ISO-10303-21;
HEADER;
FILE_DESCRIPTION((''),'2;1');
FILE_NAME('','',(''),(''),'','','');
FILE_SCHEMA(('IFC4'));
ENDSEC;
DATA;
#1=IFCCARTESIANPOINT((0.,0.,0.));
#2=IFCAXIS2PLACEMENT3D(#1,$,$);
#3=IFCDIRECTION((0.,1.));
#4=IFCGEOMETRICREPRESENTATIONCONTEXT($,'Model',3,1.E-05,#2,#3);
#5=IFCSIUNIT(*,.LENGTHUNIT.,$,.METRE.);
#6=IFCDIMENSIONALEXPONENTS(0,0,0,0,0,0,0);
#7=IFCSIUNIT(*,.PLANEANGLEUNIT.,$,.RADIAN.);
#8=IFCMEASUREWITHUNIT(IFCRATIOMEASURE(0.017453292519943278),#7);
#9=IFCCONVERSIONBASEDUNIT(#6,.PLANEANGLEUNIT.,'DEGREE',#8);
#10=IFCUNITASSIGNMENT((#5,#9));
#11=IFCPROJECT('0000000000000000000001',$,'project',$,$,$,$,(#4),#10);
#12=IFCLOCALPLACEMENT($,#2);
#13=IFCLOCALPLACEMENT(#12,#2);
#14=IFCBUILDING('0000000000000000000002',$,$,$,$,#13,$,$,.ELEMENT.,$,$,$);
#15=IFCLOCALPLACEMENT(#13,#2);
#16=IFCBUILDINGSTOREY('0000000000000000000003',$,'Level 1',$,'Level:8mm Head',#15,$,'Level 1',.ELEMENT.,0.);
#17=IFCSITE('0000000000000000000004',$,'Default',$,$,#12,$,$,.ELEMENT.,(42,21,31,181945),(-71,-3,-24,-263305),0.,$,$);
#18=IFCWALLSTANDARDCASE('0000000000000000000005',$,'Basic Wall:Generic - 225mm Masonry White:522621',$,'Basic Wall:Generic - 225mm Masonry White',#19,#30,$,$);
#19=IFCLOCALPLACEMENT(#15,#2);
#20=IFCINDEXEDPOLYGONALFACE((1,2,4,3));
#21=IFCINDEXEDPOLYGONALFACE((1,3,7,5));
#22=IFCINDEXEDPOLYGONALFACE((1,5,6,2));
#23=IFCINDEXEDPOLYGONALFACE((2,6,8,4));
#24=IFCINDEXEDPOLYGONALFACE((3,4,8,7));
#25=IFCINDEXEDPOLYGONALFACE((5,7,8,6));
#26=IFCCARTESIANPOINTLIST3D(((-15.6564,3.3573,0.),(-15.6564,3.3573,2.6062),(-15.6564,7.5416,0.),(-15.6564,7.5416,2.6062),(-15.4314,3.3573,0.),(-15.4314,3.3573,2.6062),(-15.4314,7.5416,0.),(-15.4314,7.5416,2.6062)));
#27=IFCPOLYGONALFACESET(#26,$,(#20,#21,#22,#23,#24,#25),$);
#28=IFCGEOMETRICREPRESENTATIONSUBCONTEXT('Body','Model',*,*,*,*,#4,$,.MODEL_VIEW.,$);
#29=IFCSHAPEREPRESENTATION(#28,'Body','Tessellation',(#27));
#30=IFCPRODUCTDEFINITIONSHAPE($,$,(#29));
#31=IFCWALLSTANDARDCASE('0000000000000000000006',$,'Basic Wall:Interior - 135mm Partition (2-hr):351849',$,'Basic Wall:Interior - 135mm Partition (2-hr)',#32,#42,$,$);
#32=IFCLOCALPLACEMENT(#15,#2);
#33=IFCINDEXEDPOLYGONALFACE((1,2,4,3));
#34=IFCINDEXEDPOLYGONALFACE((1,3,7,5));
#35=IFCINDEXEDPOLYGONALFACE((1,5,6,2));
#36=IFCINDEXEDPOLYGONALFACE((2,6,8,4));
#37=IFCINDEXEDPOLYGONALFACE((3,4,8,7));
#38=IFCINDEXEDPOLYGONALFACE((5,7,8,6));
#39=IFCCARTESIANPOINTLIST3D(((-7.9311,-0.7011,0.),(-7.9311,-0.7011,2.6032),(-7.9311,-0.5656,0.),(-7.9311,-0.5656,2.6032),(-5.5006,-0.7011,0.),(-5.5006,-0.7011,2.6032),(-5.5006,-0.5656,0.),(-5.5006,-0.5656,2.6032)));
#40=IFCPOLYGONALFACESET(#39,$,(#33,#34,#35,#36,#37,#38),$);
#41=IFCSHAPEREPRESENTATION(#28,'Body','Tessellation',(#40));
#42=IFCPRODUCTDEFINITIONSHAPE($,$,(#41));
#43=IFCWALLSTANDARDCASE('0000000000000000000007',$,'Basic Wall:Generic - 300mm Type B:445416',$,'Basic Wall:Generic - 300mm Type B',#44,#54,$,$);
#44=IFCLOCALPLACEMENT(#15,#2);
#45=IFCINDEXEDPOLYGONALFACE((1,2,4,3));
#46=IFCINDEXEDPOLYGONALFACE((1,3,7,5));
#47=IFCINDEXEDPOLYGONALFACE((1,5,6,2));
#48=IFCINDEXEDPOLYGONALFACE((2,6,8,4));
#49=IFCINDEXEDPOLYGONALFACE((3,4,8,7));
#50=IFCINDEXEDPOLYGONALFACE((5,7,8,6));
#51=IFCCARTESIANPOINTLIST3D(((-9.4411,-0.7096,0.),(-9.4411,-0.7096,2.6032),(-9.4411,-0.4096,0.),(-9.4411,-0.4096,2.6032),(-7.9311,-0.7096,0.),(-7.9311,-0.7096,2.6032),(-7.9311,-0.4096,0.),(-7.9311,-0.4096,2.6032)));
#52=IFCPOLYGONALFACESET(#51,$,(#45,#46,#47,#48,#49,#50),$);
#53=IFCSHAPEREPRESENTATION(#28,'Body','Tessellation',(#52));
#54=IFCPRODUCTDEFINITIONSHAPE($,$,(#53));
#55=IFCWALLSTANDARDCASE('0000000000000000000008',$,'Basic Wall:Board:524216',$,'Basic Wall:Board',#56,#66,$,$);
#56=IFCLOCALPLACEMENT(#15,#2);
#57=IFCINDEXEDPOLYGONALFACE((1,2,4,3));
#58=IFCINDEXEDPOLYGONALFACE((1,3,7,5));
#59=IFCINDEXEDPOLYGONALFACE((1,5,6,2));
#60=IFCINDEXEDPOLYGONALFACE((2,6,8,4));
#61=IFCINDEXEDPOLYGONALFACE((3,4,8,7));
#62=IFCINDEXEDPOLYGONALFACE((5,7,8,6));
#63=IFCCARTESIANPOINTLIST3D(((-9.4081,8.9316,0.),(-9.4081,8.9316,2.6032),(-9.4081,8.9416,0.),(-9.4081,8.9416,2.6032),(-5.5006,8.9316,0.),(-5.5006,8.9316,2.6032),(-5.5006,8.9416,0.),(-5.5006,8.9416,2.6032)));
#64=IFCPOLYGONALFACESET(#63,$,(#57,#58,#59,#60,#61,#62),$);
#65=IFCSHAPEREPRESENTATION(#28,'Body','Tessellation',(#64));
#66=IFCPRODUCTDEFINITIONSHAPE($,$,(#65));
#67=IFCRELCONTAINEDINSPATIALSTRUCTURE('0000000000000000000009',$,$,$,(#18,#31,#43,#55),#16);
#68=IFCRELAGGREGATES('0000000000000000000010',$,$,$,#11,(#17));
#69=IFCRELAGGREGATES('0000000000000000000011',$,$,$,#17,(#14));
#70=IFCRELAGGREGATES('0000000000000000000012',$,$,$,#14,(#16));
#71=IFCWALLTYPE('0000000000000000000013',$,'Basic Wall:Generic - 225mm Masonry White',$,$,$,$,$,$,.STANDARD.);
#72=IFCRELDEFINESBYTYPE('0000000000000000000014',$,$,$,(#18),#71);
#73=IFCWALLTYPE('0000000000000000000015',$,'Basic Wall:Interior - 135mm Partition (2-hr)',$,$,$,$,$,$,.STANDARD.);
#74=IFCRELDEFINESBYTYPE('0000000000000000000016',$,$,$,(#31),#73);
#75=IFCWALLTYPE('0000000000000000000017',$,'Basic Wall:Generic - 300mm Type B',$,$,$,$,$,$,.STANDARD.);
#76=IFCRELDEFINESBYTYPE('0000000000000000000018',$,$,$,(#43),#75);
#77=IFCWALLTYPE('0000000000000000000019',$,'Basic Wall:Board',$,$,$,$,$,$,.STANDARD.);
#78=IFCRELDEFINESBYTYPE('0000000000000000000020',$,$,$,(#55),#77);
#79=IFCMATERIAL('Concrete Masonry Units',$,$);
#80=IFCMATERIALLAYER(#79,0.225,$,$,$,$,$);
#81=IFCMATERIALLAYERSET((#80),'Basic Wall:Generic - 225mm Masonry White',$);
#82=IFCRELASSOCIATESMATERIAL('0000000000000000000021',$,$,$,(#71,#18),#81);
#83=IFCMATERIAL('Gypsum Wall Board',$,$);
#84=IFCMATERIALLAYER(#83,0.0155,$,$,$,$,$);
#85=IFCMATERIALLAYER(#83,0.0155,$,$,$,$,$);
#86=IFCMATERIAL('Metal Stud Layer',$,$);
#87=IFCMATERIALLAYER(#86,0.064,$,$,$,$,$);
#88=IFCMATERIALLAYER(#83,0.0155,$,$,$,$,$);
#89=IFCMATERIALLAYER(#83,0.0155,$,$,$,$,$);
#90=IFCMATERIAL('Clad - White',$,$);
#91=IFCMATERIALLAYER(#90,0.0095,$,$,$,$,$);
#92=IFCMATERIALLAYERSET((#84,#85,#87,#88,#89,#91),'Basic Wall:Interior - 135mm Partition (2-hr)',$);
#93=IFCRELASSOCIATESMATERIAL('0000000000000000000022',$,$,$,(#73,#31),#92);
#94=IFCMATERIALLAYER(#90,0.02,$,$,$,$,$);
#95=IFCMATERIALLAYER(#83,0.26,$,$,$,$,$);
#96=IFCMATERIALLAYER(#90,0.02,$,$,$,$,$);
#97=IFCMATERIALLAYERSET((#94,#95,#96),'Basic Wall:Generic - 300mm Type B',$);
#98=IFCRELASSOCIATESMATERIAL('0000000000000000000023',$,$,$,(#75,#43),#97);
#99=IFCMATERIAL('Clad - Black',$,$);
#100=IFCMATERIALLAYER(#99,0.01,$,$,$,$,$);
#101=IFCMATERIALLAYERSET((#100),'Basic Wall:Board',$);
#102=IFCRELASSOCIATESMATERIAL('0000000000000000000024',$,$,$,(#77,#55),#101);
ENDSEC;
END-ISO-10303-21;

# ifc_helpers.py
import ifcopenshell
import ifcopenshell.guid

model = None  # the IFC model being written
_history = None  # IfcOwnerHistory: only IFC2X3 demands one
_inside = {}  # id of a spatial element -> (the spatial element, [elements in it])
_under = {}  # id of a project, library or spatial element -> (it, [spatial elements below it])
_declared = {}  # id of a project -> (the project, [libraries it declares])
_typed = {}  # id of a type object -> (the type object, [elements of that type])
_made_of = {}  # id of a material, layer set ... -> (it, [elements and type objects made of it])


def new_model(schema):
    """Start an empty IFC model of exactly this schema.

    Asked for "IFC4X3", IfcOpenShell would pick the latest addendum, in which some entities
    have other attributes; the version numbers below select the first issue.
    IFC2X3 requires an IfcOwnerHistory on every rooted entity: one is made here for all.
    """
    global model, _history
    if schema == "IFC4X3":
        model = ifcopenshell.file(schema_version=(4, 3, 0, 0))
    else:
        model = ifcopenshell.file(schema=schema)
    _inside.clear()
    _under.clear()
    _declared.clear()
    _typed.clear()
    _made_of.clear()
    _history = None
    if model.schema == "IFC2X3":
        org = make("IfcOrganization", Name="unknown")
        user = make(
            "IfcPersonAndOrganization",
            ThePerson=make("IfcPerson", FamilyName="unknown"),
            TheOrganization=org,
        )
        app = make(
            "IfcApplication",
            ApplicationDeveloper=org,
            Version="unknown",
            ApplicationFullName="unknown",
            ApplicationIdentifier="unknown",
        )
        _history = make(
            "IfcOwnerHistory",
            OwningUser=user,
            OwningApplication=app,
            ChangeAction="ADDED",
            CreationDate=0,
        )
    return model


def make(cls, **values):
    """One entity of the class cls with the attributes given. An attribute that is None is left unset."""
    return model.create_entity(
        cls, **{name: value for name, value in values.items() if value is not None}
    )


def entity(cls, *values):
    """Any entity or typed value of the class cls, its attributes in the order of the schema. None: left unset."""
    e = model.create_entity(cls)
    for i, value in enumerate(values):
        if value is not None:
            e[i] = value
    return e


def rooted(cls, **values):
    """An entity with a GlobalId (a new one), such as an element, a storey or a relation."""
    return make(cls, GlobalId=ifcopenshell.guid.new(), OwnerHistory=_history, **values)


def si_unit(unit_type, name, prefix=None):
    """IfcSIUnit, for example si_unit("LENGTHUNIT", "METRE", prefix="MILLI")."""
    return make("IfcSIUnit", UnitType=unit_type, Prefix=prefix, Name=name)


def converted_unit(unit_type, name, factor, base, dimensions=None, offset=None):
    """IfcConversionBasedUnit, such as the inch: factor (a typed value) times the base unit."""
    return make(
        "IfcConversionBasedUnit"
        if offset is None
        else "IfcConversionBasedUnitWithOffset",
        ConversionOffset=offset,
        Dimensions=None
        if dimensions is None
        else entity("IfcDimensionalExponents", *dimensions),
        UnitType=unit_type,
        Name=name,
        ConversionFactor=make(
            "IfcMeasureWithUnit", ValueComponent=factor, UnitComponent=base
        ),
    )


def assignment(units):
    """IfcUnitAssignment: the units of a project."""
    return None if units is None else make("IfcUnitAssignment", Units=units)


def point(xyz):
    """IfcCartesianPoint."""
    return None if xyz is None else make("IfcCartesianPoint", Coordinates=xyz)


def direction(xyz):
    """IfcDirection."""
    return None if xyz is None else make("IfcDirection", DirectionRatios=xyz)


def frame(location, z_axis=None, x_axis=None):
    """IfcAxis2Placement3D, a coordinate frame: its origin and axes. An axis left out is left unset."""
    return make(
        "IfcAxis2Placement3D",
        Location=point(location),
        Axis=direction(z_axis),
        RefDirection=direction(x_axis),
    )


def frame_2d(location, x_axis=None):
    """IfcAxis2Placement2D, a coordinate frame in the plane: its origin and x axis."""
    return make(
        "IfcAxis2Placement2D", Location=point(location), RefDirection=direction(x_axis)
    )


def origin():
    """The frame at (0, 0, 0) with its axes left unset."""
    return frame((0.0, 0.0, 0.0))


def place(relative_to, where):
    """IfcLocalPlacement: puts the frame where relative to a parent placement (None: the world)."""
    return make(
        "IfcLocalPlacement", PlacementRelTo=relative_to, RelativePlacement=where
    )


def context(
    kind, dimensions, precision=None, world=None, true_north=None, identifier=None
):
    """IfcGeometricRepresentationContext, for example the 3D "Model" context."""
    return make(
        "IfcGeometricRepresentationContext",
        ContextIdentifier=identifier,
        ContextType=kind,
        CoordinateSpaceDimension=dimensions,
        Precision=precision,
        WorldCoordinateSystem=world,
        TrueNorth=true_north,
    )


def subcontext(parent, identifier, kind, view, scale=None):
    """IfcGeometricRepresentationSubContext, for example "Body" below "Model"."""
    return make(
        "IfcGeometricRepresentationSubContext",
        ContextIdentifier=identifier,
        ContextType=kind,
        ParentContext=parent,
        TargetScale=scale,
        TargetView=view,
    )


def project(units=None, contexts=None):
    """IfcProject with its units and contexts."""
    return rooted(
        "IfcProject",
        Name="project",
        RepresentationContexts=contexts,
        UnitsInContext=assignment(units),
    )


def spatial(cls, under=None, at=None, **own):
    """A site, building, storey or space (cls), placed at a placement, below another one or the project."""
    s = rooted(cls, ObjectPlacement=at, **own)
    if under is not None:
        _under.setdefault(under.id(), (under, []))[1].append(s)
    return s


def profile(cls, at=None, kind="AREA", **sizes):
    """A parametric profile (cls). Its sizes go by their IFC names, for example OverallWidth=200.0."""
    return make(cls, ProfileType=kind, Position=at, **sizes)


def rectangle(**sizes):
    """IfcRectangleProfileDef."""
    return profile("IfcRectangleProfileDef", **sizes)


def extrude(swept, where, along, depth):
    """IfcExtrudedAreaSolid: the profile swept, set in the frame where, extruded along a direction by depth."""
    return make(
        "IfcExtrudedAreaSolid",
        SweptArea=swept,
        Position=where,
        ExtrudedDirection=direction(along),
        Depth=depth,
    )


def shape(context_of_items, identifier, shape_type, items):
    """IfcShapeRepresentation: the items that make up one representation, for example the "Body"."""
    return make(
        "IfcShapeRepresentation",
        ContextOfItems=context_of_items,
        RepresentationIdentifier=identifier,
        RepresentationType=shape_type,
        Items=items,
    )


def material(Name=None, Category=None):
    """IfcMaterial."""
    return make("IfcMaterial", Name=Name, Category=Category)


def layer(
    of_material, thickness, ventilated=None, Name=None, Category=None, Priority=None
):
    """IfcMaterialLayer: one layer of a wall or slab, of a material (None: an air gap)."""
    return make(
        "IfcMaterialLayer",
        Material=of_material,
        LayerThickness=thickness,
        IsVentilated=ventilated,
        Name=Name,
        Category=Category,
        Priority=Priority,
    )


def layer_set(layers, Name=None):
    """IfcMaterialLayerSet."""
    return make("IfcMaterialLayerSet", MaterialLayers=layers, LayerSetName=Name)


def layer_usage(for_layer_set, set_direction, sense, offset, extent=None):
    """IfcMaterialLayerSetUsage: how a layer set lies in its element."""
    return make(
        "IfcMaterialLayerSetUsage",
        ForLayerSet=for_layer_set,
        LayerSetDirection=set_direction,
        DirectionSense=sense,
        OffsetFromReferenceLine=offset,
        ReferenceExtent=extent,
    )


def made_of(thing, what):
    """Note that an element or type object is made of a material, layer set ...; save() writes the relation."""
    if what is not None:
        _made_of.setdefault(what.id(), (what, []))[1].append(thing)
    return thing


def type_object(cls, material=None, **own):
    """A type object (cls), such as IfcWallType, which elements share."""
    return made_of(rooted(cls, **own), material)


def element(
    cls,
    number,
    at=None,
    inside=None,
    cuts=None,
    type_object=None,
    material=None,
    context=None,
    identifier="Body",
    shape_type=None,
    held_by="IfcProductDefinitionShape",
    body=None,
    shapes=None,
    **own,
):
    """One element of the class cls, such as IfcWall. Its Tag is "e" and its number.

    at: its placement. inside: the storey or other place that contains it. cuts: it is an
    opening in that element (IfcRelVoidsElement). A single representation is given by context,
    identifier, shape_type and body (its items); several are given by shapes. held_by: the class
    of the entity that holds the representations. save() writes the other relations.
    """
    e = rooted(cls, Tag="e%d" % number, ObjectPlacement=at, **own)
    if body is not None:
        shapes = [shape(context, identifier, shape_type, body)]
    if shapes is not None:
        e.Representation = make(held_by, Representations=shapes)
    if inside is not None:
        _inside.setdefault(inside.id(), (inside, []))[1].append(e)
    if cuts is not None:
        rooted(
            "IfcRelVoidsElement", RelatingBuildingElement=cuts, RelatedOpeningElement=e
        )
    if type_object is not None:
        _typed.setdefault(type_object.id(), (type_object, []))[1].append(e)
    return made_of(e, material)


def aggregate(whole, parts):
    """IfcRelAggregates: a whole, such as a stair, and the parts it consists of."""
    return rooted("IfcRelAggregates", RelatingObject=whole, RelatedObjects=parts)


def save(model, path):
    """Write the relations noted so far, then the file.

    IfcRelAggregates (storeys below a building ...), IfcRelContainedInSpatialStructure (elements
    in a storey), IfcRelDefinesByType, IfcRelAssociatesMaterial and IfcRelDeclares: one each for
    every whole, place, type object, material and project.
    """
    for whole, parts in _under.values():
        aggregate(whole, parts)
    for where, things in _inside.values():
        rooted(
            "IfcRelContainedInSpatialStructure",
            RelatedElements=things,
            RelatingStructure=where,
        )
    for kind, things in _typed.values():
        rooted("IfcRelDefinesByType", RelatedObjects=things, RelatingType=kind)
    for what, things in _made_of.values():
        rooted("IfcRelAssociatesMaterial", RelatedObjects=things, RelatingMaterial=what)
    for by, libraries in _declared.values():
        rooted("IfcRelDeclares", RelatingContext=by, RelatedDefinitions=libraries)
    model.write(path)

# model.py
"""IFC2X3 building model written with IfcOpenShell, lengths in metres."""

from ifc_helpers import new_model, entity, si_unit, converted_unit, direction, frame, frame_2d, origin, place, context, subcontext, project, spatial, rectangle, extrude, material, layer, layer_set, layer_usage, type_object, element, save


model = new_model("IFC2X3")

# Units and contexts
model_context = context("Model", 3, precision=1e-05, world=origin(), true_north=direction((0.0, 1.0)))
body_context = subcontext(model_context, "Body", "Model", "MODEL_VIEW")
ifc_project = project(units=[si_unit("LENGTHUNIT", "METRE"), converted_unit("PLANEANGLEUNIT", "DEGREE", entity("IfcRatioMeasure", 0.017453292519943278), si_unit("PLANEANGLEUNIT", "RADIAN"), dimensions=[0, 0, 0, 0, 0, 0, 0])], contexts=[model_context])

# Site, building, storey
site_placement = place(None, origin())
site = spatial("IfcSite", under=ifc_project, at=site_placement, Name="Default", CompositionType="ELEMENT", RefLatitude=(42, 21, 31, 181945), RefLongitude=(-71, -3, -24, -263305), RefElevation=0.0)
building_placement = place(site_placement, origin())
building = spatial("IfcBuilding", under=site, at=building_placement, CompositionType="ELEMENT")
storey_placement = place(building_placement, origin())
storey = spatial("IfcBuildingStorey", under=building, at=storey_placement, Name="Level 1", ObjectType="Level:8mm Head", LongName="Level 1", CompositionType="ELEMENT", Elevation=0.0)

# Shared definitions
ifc_material_1 = material(Name="Clad - White")

# Shared definitions
ifc_material_2 = material(Name="Gypsum Wall Board")

# Shared definitions
ifc_material_3 = material(Name="Concrete Masonry Units")
ifc_layer_1 = layer(ifc_material_3, 0.225)
ifc_layer_set_1 = layer_set([ifc_layer_1], Name="Basic Wall:Generic - 225mm Masonry White")
wall_type_1 = type_object("IfcWallType", Name="Basic Wall:Generic - 225mm Masonry White", PredefinedType="STANDARD", material=ifc_layer_set_1)

# Walls
ifc_layer_usage_1 = layer_usage(ifc_layer_set_1, "AXIS2", "NEGATIVE", 0.1125)
wall_1_placement = place(storey_placement, frame((-15.5439, 3.3573, 0.0), z_axis=(0.0, 0.0, 1.0), x_axis=(0.0, 1.0, 0.0)))
element("IfcWallStandardCase", 1, at=wall_1_placement, inside=storey, type_object=wall_type_1, material=ifc_layer_usage_1, Name="Basic Wall:Generic - 225mm Masonry White:522621", ObjectType="Basic Wall:Generic - 225mm Masonry White", context=body_context, shape_type="SweptSolid", body=[
    extrude(rectangle(XDim=4.1844, YDim=0.225, at=frame_2d((2.0922, 0.0), x_axis=(-1.0, 0.0))), origin(), (0.0, 0.0, 1.0), 2.6062),
])
ifc_layer_2 = layer(ifc_material_2, 0.0155)
ifc_layer_3 = layer(ifc_material_2, 0.0155)
ifc_material_4 = material(Name="Metal Stud Layer")
ifc_layer_4 = layer(ifc_material_4, 0.064)
ifc_layer_5 = layer(ifc_material_2, 0.0155)
ifc_layer_6 = layer(ifc_material_2, 0.0155)
ifc_layer_7 = layer(ifc_material_1, 0.0095)
ifc_layer_set_2 = layer_set([ifc_layer_2, ifc_layer_3, ifc_layer_4, ifc_layer_5, ifc_layer_6, ifc_layer_7], Name="Basic Wall:Interior - 135mm Partition (2-hr)")
ifc_layer_usage_2 = layer_usage(ifc_layer_set_2, "AXIS2", "NEGATIVE", 0.0677)
wall_type_2 = type_object("IfcWallType", Name="Basic Wall:Interior - 135mm Partition (2-hr)", PredefinedType="STANDARD", material=ifc_layer_set_2)
wall_2_placement = place(storey_placement, frame((-5.5006, -0.6334, 0.0), z_axis=(0.0, 0.0, 1.0), x_axis=(-1.0, 0.0, 0.0)))
element("IfcWallStandardCase", 2, at=wall_2_placement, inside=storey, type_object=wall_type_2, material=ifc_layer_usage_2, Name="Basic Wall:Interior - 135mm Partition (2-hr):351849", ObjectType="Basic Wall:Interior - 135mm Partition (2-hr)", context=body_context, shape_type="SweptSolid", body=[
    extrude(rectangle(XDim=2.4306, YDim=0.1355, at=frame_2d((1.2153, 0.0), x_axis=(-1.0, 0.0))), origin(), (0.0, 0.0, 1.0), 2.6032),
])

# Walls
ifc_layer_8 = layer(ifc_material_1, 0.02)
ifc_layer_9 = layer(ifc_material_2, 0.26)
ifc_layer_10 = layer(ifc_material_1, 0.02)
ifc_layer_set_3 = layer_set([ifc_layer_8, ifc_layer_9, ifc_layer_10], Name="Basic Wall:Generic - 300mm Type B")
ifc_layer_usage_3 = layer_usage(ifc_layer_set_3, "AXIS2", "NEGATIVE", 0.15)
wall_type_3 = type_object("IfcWallType", Name="Basic Wall:Generic - 300mm Type B", PredefinedType="STANDARD", material=ifc_layer_set_3)
wall_3_placement = place(storey_placement, frame((-7.9311, -0.5596, 0.0), z_axis=(0.0, 0.0, 1.0), x_axis=(-1.0, 0.0, 0.0)))
element("IfcWallStandardCase", 3, at=wall_3_placement, inside=storey, type_object=wall_type_3, material=ifc_layer_usage_3, Name="Basic Wall:Generic - 300mm Type B:445416", ObjectType="Basic Wall:Generic - 300mm Type B", context=body_context, shape_type="SweptSolid", body=[
    extrude(rectangle(XDim=1.51, YDim=0.3, at=frame_2d((0.755, 0.0), x_axis=(-1.0, 0.0))), origin(), (0.0, 0.0, 1.0), 2.6032),
])
ifc_material_5 = material(Name="Clad - Black")
ifc_layer_11 = layer(ifc_material_5, 0.01)
ifc_layer_set_4 = layer_set([ifc_layer_11], Name="Basic Wall:Board")
ifc_layer_usage_4 = layer_usage(ifc_layer_set_4, "AXIS2", "NEGATIVE", 0.005)
wall_type_4 = type_object("IfcWallType", Name="Basic Wall:Board", PredefinedType="STANDARD", material=ifc_layer_set_4)
wall_4_placement = place(storey_placement, frame((-5.5006, 8.9366, 0.0), z_axis=(0.0, 0.0, 1.0), x_axis=(-1.0, 0.0, 0.0)))
element("IfcWallStandardCase", 4, at=wall_4_placement, inside=storey, type_object=wall_type_4, material=ifc_layer_usage_4, Name="Basic Wall:Board:524216", ObjectType="Basic Wall:Board", context=body_context, shape_type="SweptSolid", body=[
    extrude(rectangle(XDim=3.9075, YDim=0.01, at=frame_2d((1.9538, 0.0), x_axis=(-1.0, 0.0))), origin(), (0.0, 0.0, 1.0), 2.6032),
])

save(model, "model.ifc")
